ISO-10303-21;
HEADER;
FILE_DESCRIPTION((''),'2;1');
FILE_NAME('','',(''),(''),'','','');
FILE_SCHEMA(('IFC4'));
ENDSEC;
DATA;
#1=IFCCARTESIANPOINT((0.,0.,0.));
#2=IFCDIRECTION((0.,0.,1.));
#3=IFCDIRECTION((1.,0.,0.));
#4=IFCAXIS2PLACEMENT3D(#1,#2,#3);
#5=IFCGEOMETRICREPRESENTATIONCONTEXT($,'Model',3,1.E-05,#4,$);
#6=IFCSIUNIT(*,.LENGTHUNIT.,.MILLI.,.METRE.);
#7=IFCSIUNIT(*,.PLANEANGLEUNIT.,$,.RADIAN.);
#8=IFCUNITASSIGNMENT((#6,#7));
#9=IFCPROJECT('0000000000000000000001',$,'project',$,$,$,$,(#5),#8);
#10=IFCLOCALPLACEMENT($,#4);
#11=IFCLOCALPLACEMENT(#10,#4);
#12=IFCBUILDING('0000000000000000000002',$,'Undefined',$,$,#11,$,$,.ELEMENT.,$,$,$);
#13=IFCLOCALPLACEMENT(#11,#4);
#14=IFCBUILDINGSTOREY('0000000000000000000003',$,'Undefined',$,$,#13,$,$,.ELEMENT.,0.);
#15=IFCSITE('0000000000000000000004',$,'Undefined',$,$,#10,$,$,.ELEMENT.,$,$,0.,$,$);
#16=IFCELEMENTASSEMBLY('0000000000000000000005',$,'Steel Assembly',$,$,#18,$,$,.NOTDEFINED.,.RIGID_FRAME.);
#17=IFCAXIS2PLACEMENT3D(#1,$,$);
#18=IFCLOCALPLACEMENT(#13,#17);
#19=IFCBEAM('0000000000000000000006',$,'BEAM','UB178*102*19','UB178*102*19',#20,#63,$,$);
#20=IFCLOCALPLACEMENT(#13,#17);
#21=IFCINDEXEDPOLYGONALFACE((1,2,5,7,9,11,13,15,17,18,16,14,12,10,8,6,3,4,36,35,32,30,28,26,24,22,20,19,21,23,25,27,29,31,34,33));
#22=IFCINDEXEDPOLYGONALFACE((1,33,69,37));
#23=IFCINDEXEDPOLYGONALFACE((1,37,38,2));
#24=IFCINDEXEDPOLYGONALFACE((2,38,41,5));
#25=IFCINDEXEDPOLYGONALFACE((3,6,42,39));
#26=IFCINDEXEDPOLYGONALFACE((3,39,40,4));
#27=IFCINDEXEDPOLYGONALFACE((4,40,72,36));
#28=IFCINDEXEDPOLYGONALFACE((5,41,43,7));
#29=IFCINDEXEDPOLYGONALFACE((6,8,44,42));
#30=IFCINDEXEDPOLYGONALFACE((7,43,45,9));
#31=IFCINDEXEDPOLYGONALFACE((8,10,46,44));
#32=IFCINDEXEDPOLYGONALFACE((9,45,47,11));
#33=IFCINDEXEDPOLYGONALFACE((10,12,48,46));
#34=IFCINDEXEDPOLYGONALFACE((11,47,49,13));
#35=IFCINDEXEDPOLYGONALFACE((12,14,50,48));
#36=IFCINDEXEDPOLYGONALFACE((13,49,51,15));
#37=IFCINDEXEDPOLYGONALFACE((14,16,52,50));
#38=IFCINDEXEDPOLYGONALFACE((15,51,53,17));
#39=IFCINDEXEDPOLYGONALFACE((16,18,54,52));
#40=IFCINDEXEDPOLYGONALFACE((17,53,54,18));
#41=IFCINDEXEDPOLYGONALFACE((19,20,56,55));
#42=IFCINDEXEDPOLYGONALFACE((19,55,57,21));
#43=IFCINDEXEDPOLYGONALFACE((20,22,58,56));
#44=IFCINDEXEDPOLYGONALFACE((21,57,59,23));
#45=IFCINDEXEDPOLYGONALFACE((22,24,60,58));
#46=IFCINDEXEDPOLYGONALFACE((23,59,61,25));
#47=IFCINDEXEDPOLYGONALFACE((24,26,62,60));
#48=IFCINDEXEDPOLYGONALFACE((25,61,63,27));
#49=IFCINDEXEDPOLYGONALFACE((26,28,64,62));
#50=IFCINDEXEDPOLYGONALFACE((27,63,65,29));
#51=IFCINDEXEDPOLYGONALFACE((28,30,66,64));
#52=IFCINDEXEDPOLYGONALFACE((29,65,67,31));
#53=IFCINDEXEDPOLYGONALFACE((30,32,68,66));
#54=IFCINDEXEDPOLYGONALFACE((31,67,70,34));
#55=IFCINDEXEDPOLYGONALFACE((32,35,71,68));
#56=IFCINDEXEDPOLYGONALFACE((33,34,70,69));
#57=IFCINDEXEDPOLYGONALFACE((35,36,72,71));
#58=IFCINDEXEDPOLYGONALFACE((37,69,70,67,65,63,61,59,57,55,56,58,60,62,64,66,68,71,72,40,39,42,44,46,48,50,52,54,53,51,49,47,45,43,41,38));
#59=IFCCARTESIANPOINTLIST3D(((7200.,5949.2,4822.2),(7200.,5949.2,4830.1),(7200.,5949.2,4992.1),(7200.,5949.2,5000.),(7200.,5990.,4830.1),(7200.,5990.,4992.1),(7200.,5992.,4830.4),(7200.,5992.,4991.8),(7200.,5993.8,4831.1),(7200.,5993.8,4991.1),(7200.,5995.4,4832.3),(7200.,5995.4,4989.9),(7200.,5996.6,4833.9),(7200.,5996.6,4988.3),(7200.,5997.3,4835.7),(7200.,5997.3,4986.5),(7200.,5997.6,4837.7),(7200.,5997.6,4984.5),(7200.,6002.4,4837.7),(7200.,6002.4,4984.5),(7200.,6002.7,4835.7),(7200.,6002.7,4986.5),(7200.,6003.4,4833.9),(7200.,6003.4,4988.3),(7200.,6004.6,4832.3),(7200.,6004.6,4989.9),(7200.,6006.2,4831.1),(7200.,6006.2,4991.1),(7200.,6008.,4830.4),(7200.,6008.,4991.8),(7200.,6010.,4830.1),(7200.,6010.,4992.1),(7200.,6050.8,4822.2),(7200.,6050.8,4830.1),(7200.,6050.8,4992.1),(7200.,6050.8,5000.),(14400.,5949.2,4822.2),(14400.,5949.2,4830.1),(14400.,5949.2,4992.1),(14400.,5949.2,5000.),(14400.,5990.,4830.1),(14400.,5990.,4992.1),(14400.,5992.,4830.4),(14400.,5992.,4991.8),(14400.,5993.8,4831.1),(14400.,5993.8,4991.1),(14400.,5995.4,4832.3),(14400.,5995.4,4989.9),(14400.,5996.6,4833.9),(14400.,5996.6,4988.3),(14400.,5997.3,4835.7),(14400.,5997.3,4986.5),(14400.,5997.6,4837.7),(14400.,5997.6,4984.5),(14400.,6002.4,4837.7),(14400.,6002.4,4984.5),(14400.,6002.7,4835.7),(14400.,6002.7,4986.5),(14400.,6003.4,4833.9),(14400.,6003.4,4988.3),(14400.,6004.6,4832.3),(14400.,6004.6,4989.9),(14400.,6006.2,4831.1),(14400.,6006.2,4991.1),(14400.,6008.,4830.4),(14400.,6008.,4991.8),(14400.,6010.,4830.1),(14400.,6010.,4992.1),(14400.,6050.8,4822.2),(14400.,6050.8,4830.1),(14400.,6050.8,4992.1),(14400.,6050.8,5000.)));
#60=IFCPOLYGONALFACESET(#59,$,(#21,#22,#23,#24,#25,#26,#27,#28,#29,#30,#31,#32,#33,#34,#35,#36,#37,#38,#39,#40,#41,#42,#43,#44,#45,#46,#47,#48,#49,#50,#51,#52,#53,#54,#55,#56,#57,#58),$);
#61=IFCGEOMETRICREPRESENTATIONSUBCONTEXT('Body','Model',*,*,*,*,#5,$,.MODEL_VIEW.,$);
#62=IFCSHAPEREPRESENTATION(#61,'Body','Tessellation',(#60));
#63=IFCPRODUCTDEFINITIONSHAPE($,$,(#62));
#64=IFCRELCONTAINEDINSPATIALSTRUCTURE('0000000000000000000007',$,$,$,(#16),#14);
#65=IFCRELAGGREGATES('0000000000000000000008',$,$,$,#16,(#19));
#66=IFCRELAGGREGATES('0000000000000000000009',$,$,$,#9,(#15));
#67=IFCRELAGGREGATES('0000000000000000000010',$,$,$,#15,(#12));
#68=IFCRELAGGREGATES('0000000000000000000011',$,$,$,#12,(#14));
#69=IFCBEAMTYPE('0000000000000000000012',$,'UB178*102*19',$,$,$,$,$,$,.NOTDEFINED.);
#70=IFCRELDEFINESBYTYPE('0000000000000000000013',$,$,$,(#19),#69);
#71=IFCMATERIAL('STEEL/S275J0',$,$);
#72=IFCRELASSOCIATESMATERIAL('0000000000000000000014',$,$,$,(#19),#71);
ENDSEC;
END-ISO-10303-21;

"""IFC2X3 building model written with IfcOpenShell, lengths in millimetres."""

from ifc_helpers import new_model, si_unit, frame, origin_with_axes, origin_2d_with_axis, place, context, subcontext, project, spatial, i_section, extrude, material, type_object, element, aggregate, save


model = new_model("IFC2X3")

# Units and contexts
model_context = context("Model", 3, precision=1e-05, world=origin_with_axes())
body_context = subcontext(model_context, "Body", "Model", "MODEL_VIEW")
ifc_project = project(units=[si_unit("LENGTHUNIT", "METRE", prefix="MILLI"), si_unit("PLANEANGLEUNIT", "RADIAN")], contexts=[model_context])

# Site, building, storey
site_placement = place(None, origin_with_axes())
site = spatial("IfcSite", under=ifc_project, at=site_placement, Name="Undefined", CompositionType="ELEMENT", RefElevation=0.0)
building_placement = place(site_placement, origin_with_axes())
building = spatial("IfcBuilding", under=site, at=building_placement, Name="Undefined", CompositionType="ELEMENT")
storey_placement = place(building_placement, origin_with_axes())
storey = spatial("IfcBuildingStorey", under=building, at=storey_placement, Name="Undefined", CompositionType="ELEMENT", Elevation=0.0)

# Shared definitions
ifc_material = material(Name="STEEL/S275J0")

# Element assembly, beam
beam_type_1 = type_object("IfcBeamType", Name="UB178*102*19", PredefinedType="NOTDEFINED")
assembly_1_placement = place(storey_placement, origin_with_axes())
assembly_1 = element("IfcElementAssembly", 1, at=assembly_1_placement, inside=storey, Name="Steel Assembly", AssemblyPlace="NOTDEFINED", PredefinedType="RIGID_FRAME")
beam_1_placement = place(assembly_1_placement, frame((7200.0, 6000.0, 4911.1), z_axis=(0.0, 0.0, 1.0), x_axis=(1.0, 0.0, 0.0)))
beam_1 = element("IfcBeam", 2, at=beam_1_placement, type_object=beam_type_1, material=ifc_material, Name="BEAM", Description="UB178*102*19", ObjectType="UB178*102*19", context=body_context, shape_type="SweptSolid", body=[
    extrude(i_section(OverallWidth=101.6, OverallDepth=177.8, WebThickness=4.8, FlangeThickness=7.9, FilletRadius=7.6, at=origin_2d_with_axis()), frame((7200.0, 0.0, 0.0), z_axis=(-1.0, 0.0, 0.0), x_axis=(0.0, -1.0, 0.0)), (0.0, 0.0, 1.0), 7200.0),
])
aggregate(assembly_1, [beam_1])

save(model, "model.ifc")
